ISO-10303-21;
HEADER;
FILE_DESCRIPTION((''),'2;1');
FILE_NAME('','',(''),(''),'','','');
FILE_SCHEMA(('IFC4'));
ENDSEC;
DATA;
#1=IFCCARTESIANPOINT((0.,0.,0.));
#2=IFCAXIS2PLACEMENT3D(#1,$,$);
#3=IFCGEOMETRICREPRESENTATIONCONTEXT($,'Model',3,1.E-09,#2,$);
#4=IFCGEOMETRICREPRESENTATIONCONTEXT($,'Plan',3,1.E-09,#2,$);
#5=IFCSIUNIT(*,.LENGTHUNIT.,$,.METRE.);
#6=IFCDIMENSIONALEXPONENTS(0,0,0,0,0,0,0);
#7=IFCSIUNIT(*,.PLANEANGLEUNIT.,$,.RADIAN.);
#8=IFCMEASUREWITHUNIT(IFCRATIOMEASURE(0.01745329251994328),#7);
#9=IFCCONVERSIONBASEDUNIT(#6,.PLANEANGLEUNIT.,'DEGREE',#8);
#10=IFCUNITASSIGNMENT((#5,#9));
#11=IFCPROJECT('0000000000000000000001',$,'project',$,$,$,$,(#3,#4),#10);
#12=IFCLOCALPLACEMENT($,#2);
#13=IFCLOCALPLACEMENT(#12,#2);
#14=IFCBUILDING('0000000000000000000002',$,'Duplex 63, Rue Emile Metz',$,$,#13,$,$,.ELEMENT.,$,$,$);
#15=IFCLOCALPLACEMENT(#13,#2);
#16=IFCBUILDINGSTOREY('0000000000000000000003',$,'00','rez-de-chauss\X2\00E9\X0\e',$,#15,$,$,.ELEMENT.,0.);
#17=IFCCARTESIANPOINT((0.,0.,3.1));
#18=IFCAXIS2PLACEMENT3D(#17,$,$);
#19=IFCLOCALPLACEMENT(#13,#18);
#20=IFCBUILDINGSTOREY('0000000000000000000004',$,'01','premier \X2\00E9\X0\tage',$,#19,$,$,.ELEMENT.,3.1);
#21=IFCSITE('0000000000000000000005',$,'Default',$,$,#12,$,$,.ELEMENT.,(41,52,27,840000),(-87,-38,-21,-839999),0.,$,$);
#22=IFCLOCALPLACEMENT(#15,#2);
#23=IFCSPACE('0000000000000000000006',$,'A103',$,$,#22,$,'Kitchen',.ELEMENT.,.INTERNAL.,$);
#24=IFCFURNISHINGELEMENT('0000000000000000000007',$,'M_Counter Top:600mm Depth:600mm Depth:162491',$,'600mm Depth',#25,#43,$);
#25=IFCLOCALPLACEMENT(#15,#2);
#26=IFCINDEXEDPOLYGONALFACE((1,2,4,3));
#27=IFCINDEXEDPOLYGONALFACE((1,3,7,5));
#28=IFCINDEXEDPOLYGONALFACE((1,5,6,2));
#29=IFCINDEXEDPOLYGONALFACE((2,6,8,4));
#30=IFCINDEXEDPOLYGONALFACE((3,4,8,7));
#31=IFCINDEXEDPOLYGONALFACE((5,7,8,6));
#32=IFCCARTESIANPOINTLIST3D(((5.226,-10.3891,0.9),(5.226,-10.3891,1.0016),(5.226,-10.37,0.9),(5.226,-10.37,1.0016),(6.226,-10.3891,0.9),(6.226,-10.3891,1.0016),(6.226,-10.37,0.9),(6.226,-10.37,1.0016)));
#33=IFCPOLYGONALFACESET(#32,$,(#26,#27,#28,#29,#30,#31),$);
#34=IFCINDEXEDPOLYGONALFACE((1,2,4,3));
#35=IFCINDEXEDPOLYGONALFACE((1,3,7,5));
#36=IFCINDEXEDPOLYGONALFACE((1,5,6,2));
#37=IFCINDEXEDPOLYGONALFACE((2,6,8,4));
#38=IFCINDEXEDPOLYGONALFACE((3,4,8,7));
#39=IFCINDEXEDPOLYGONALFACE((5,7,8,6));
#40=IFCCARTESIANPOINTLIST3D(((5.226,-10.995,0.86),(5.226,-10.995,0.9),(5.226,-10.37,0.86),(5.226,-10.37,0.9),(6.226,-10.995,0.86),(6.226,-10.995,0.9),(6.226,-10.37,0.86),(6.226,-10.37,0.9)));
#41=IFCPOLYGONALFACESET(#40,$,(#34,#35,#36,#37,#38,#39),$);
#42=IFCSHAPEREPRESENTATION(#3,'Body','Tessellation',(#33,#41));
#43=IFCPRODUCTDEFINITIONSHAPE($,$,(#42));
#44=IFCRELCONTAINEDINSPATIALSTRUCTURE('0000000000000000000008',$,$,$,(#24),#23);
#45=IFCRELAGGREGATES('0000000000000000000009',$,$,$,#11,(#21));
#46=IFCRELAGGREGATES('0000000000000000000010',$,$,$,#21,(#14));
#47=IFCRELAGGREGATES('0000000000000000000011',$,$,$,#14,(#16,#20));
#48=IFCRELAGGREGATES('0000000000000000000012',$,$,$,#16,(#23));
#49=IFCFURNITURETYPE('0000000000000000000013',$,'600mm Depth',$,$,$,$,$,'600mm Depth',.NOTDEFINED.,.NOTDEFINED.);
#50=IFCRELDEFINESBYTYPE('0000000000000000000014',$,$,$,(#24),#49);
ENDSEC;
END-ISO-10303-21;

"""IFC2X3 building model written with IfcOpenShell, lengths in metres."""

from ifc_helpers import new_model, entity, si_unit, converted_unit, frame, origin, origin_2d_with_axis, place, context, project, spatial, rectangle, extrude, source, transform, mapped, type_object, type_shapes, element, save


model = new_model("IFC2X3")

# Units and contexts
model_context = context("Model", 3, precision=1e-09, world=origin())
plan_context = context("Plan", 3, precision=1e-09, world=origin())
ifc_project = project(units=[si_unit("LENGTHUNIT", "METRE"), converted_unit("PLANEANGLEUNIT", "DEGREE", entity("IfcRatioMeasure", 0.01745329251994328), si_unit("PLANEANGLEUNIT", "RADIAN"), dimensions=[0, 0, 0, 0, 0, 0, 0])], contexts=[model_context, plan_context])

# Site, building, storey
site_placement = place(None, origin())
site = spatial("IfcSite", under=ifc_project, at=site_placement, Name="Default", CompositionType="ELEMENT", RefLatitude=(41, 52, 27, 840000), RefLongitude=(-87, -38, -21, -839999), RefElevation=0.0)
building_placement = place(site_placement, origin())
building = spatial("IfcBuilding", under=site, at=building_placement, Name="Duplex 63, Rue Emile Metz", CompositionType="ELEMENT")
storey_1_placement = place(building_placement, origin())
storey_1 = spatial("IfcBuildingStorey", under=building, at=storey_1_placement, Name="00", Description="rez-de-chaussée", CompositionType="ELEMENT", Elevation=0.0)

# Shared definitions
storey_2_placement = place(building_placement, frame((0.0, 0.0, 3.1)))
storey_2 = spatial("IfcBuildingStorey", under=building, at=storey_2_placement, Name="01", Description="premier étage", CompositionType="ELEMENT", Elevation=3.1)

# Shared definitions
space_1_placement = place(storey_1_placement, origin())
space_1 = spatial("IfcSpace", under=storey_1, at=space_1_placement, Name="A103", LongName="Kitchen", CompositionType="ELEMENT", InteriorOrExteriorSpace="INTERNAL")

# Furnishing element
furniture_type_1 = type_object("IfcFurnitureType", Name="600mm Depth", ElementType="600mm Depth", AssemblyPlace="NOTDEFINED")
shared_shape_1 = source(origin(), model_context, "Body", "SweptSolid", [
    extrude(rectangle(XDim=0.0191, YDim=1.0, at=origin_2d_with_axis()), frame((-0.7005, -0.0095, 0.9), z_axis=(0.0, 0.0, 1.0), x_axis=(0.0, -1.0, 0.0)), (0.0, 0.0, 1.0), 0.1016),
    extrude(rectangle(XDim=1.0, YDim=0.625, at=origin_2d_with_axis()), frame((-0.7005, -0.3125, 0.86), z_axis=(0.0, 0.0, 1.0), x_axis=(-1.0, 0.0, 0.0)), (0.0, 0.0, 1.0), 0.04),
])
type_shapes(furniture_type_1, [shared_shape_1])
furnishing_1_placement = place(space_1_placement, frame((6.4265, -10.37, 0.0)))
element("IfcFurnishingElement", 1, at=furnishing_1_placement, inside=space_1, type_object=furniture_type_1, Name="M_Counter Top:600mm Depth:600mm Depth:162491", ObjectType="600mm Depth", context=model_context, shape_type="MappedRepresentation", body=[
    mapped(shared_shape_1, transform((0.0, 0.0, 0.0), scale=1.0)),
])

save(model, "model.ifc")
